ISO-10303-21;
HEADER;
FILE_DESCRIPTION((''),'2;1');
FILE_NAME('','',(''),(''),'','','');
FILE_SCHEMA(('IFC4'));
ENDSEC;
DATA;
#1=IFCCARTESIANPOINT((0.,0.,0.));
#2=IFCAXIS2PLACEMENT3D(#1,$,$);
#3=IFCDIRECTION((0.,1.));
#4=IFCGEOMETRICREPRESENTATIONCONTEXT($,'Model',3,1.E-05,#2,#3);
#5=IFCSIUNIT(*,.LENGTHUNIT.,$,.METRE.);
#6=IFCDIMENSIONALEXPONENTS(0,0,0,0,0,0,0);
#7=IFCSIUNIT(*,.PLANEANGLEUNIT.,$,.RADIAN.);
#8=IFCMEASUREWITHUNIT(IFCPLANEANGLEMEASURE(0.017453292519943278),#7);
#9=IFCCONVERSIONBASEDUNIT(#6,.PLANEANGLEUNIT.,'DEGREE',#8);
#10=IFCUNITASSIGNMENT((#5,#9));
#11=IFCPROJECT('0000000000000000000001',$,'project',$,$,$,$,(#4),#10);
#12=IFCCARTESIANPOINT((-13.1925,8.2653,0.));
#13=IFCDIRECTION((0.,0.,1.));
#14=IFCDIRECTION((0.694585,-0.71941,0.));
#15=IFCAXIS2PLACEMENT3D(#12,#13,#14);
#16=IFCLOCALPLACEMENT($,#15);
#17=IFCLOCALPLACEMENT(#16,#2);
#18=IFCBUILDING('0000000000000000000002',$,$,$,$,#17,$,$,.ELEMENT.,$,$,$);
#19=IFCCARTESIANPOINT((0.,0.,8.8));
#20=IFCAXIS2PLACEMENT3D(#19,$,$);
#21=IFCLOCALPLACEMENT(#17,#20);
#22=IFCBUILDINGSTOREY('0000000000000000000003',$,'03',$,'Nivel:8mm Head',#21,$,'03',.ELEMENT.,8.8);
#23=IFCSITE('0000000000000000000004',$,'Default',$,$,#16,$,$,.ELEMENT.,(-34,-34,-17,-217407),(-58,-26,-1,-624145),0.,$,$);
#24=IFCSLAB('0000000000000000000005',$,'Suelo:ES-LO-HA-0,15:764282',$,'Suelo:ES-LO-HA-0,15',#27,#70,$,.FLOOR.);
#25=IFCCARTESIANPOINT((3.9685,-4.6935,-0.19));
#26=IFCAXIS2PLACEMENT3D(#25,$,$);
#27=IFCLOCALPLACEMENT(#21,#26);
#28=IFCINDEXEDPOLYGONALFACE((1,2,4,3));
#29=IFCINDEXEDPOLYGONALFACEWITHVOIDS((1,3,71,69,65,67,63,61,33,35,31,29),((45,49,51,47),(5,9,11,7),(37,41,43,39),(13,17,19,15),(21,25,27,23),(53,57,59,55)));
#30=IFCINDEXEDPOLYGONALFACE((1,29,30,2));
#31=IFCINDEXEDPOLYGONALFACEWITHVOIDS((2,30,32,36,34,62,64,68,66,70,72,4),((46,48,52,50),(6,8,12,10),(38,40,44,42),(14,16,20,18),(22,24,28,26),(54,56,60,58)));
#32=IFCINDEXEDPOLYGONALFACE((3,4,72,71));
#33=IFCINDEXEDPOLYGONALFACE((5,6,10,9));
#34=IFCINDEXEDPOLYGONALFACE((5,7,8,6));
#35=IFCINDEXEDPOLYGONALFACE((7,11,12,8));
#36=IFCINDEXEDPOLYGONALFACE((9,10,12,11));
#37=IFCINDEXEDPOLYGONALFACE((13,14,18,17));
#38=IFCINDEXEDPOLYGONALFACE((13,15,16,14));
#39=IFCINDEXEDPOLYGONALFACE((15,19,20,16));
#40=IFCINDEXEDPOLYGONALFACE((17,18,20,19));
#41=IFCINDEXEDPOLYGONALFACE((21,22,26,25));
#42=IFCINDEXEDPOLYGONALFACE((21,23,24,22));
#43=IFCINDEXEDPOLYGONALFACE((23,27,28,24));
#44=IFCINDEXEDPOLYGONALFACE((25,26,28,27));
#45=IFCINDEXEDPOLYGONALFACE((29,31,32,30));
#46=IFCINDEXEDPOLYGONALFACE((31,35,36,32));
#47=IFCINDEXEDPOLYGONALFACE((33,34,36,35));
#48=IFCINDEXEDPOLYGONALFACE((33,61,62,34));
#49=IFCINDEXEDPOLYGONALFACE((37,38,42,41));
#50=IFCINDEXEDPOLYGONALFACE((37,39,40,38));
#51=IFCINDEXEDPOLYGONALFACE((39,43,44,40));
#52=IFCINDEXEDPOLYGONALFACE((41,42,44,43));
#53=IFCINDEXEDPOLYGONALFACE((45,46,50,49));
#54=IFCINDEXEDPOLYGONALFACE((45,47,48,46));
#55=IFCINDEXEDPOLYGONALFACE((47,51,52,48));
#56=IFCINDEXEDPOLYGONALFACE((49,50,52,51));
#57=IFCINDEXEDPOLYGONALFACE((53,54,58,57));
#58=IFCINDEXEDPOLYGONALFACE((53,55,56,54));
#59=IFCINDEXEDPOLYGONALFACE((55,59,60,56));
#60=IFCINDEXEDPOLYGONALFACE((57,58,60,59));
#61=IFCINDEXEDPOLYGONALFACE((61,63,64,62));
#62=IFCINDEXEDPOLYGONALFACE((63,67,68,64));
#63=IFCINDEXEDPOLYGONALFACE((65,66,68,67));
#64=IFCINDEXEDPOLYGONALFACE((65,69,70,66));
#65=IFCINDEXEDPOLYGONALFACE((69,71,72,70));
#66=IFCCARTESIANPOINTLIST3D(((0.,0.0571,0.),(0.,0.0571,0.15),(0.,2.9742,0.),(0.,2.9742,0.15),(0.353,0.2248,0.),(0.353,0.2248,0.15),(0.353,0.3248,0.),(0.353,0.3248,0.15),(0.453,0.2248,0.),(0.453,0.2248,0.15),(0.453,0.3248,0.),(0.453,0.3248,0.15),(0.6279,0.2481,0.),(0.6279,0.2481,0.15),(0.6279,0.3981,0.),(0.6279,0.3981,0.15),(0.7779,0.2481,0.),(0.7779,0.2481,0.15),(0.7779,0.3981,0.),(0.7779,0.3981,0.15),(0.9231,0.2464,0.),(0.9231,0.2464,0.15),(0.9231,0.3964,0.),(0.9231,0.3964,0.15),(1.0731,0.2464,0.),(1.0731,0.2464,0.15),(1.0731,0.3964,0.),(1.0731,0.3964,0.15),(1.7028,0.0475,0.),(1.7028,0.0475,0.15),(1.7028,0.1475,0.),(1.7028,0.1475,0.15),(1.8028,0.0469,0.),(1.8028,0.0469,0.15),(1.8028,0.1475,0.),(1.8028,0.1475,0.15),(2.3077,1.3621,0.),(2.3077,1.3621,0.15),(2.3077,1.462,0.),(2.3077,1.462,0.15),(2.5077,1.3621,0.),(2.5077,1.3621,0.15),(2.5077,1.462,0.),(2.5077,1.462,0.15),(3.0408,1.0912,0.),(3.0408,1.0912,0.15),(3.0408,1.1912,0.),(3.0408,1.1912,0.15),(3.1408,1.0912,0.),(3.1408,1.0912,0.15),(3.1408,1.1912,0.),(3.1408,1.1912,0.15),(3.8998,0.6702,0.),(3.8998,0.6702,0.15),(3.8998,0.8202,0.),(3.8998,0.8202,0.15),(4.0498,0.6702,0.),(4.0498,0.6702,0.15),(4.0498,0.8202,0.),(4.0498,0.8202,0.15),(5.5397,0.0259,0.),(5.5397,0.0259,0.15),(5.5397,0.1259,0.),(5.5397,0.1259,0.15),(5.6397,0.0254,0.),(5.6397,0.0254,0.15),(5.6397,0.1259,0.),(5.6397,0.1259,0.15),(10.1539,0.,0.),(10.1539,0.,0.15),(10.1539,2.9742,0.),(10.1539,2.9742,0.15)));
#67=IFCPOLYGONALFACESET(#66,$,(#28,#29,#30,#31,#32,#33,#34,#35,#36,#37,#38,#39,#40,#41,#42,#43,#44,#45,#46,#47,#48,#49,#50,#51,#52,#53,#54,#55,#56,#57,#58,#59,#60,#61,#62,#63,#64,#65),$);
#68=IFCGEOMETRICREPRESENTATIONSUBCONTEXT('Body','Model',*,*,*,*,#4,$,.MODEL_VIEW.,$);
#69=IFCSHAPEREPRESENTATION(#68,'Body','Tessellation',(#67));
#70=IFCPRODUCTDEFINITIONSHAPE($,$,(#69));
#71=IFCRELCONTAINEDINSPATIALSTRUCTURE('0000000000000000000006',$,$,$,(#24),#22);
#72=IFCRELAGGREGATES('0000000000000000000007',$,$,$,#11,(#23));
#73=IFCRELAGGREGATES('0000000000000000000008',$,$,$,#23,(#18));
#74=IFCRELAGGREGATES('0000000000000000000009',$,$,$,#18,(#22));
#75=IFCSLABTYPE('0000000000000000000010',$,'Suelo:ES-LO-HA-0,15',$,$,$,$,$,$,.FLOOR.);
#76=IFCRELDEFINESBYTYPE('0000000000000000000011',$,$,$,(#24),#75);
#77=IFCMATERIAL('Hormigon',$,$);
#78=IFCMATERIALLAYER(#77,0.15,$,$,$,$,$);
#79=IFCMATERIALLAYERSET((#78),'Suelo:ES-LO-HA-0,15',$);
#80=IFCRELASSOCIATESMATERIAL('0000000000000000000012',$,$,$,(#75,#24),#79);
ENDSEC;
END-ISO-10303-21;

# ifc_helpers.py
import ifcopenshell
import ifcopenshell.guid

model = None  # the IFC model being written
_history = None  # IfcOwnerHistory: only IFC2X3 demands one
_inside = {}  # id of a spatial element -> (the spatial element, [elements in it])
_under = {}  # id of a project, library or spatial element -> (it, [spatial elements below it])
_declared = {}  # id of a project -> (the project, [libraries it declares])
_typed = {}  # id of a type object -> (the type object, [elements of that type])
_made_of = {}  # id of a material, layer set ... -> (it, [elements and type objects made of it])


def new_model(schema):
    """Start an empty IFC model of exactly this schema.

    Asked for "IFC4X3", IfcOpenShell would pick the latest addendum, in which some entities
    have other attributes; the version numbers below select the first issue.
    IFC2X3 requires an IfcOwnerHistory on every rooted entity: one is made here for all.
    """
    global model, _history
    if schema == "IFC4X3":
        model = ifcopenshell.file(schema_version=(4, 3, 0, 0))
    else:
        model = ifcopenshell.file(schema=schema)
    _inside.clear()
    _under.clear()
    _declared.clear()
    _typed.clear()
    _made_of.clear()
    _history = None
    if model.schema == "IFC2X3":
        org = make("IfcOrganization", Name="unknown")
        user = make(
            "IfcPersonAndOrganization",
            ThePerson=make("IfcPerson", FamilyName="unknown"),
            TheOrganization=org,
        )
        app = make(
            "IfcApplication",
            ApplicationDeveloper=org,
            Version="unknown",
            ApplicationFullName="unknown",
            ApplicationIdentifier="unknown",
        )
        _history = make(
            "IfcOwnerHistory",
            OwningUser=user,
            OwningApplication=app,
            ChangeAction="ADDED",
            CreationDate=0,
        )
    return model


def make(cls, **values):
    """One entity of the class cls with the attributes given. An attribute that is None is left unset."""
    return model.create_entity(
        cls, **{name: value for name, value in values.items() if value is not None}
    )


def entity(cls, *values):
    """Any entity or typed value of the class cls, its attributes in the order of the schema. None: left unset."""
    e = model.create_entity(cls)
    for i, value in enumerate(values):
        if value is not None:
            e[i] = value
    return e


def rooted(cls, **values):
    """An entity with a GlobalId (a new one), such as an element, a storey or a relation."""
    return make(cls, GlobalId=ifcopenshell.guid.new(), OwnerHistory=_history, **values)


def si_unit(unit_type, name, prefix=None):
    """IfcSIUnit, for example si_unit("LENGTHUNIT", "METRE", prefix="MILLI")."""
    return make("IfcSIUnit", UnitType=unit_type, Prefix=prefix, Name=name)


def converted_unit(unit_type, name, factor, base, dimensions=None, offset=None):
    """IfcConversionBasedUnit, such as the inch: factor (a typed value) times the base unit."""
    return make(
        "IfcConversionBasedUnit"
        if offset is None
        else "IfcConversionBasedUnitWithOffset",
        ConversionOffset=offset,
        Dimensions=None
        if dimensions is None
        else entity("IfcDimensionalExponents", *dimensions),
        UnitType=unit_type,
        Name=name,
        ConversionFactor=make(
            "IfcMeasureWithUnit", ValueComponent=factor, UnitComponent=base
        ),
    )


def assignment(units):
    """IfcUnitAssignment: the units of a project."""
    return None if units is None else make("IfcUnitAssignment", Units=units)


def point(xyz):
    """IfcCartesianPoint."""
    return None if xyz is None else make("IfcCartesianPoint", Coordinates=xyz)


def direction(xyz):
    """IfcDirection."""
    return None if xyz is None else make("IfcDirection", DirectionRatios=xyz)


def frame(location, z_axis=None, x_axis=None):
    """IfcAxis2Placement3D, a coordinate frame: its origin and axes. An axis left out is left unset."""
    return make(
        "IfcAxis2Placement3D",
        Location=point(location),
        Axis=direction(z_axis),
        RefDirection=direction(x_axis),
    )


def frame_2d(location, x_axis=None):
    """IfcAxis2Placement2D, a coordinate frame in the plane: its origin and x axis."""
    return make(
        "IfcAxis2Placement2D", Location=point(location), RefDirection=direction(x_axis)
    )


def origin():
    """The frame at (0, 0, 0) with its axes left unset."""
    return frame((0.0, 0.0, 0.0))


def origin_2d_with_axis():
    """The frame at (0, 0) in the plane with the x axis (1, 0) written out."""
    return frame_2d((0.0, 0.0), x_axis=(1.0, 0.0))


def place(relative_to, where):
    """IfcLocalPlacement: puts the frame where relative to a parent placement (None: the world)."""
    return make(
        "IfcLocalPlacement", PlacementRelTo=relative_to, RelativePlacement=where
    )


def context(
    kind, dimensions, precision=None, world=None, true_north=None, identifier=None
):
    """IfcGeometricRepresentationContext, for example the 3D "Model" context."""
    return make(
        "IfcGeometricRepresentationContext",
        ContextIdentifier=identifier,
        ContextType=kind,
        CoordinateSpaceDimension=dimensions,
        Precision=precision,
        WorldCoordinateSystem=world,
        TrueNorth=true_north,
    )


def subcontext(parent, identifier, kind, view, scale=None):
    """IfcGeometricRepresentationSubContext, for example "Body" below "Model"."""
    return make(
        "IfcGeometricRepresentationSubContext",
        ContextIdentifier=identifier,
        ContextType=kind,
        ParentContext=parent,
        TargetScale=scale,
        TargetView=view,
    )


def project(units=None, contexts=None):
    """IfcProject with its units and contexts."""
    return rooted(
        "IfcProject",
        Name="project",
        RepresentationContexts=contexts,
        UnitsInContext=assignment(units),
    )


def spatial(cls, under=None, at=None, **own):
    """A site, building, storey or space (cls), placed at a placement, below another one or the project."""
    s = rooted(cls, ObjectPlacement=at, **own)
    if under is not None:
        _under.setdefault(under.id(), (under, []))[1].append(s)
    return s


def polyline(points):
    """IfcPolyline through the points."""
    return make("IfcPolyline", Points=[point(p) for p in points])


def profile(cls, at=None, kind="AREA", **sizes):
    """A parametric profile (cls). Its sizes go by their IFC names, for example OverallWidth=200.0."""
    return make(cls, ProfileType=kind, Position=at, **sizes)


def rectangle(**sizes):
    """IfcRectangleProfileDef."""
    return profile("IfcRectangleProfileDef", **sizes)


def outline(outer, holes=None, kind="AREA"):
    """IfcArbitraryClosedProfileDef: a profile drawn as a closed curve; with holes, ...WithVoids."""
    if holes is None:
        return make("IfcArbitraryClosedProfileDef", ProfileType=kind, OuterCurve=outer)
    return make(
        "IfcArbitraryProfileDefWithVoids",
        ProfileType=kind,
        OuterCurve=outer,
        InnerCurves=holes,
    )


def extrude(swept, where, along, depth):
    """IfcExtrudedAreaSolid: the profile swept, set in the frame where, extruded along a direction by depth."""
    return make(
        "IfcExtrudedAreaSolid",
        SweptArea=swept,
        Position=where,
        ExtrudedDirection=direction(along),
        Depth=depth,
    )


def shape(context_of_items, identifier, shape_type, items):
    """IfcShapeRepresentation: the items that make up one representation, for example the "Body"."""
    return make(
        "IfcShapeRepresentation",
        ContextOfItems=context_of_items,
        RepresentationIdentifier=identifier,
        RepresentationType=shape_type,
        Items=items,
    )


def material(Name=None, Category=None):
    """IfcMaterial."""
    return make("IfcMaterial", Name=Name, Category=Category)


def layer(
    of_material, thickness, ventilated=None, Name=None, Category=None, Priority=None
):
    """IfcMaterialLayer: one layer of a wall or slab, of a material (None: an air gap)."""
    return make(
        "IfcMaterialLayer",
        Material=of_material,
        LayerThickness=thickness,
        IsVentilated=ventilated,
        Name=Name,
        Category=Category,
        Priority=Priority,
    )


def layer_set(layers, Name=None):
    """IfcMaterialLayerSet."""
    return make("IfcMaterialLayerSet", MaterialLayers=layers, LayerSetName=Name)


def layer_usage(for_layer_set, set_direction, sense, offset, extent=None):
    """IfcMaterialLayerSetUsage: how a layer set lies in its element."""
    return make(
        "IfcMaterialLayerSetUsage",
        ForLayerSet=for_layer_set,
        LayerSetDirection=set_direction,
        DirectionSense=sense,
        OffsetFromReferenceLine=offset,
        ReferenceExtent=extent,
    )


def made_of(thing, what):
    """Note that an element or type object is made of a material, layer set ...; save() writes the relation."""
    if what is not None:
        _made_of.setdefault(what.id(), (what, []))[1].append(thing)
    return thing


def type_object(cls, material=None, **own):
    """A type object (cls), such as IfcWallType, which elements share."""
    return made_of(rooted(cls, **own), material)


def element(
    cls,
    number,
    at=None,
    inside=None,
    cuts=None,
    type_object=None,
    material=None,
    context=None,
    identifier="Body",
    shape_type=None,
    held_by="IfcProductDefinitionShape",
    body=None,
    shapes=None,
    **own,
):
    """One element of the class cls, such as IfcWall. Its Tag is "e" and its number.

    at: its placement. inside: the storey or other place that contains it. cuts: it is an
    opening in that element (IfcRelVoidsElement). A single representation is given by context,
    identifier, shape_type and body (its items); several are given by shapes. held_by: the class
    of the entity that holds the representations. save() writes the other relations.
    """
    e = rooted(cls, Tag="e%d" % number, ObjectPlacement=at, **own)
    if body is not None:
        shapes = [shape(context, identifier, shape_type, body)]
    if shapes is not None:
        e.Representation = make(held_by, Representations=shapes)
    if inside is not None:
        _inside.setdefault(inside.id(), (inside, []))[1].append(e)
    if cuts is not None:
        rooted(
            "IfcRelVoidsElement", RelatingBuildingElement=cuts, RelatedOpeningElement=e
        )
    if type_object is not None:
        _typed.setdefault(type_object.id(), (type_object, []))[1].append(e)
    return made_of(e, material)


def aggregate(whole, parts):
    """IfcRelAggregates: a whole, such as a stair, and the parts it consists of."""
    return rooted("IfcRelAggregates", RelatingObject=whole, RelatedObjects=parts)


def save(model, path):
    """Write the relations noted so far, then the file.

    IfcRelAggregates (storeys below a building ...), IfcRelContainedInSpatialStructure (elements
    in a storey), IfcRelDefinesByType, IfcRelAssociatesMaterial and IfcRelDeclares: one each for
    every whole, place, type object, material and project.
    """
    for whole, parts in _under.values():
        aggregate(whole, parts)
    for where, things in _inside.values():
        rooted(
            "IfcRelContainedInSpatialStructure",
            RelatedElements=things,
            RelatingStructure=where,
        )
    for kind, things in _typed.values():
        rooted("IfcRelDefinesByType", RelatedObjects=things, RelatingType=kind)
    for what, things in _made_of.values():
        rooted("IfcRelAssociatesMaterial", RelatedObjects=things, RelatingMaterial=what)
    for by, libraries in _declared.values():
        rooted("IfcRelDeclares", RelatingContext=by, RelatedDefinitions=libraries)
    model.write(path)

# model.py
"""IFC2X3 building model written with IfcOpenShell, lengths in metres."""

from ifc_helpers import new_model, entity, si_unit, converted_unit, direction, frame, frame_2d, origin, origin_2d_with_axis, place, context, subcontext, project, spatial, polyline, rectangle, outline, extrude, material, layer, layer_set, layer_usage, type_object, element, save


model = new_model("IFC2X3")

# Units and contexts
model_context = context("Model", 3, precision=1e-05, world=origin(), true_north=direction((0.0, 1.0)))
body_context = subcontext(model_context, "Body", "Model", "MODEL_VIEW")
ifc_project = project(units=[si_unit("LENGTHUNIT", "METRE"), converted_unit("PLANEANGLEUNIT", "DEGREE", entity("IfcPlaneAngleMeasure", 0.017453292519943278), si_unit("PLANEANGLEUNIT", "RADIAN"), dimensions=[0, 0, 0, 0, 0, 0, 0])], contexts=[model_context])

# Site, building, storey
site_placement = place(None, frame((-13.1925, 8.2653, 0.0), z_axis=(0.0, 0.0, 1.0), x_axis=(0.694585, -0.71941, 0.0)))
site = spatial("IfcSite", under=ifc_project, at=site_placement, Name="Default", CompositionType="ELEMENT", RefLatitude=(-34, -34, -17, -217407), RefLongitude=(-58, -26, -1, -624145), RefElevation=0.0)
building_placement = place(site_placement, origin())
building = spatial("IfcBuilding", under=site, at=building_placement, CompositionType="ELEMENT")
storey_placement = place(building_placement, frame((0.0, 0.0, 8.8)))
storey = spatial("IfcBuildingStorey", under=building, at=storey_placement, Name="03", ObjectType="Nivel:8mm Head", LongName="03", CompositionType="ELEMENT", Elevation=8.8)

# Shared definitions
ifc_material_1 = material(Name="Hormigon")

# Slab, openings
ifc_layer = layer(ifc_material_1, 0.15)
ifc_layer_set = layer_set([ifc_layer], Name="Suelo:ES-LO-HA-0,15")
ifc_layer_usage = layer_usage(ifc_layer_set, "AXIS3", "POSITIVE", 0.0)
slab_type = type_object("IfcSlabType", Name="Suelo:ES-LO-HA-0,15", PredefinedType="FLOOR", material=ifc_layer_set)
slab_placement = place(storey_placement, frame((3.9685, -4.6935, -0.19)))
slab = element("IfcSlab", 1, at=slab_placement, inside=storey, type_object=slab_type, material=ifc_layer_usage, Name="Suelo:ES-LO-HA-0,15:764282", ObjectType="Suelo:ES-LO-HA-0,15", PredefinedType="FLOOR", context=body_context, shape_type="SweptSolid", body=[
    extrude(outline(polyline([(-5.077, 1.4871), (-5.077, -1.4871), (-0.5627, -1.4617), (-0.5627, -1.3612), (-0.4627, -1.3612), (-0.4627, -1.4612), (3.2742, -1.4402), (3.2742, -1.3396), (3.3742, -1.3396), (3.3742, -1.4396), (5.077, -1.43), (5.077, 1.4871), (-5.077, 1.4871)])), frame((5.077, 1.4871, 0.15), z_axis=(0.0, 0.0, -1.0), x_axis=(-1.0, 0.0, 0.0)), (0.0, 0.0, 1.0), 0.15),
])
opening_1_placement = place(slab_placement, origin())
element("IfcOpeningElement", 2, at=opening_1_placement, cuts=slab, ObjectType="Opening", context=body_context, shape_type="SweptSolid", body=[
    extrude(rectangle(XDim=0.1, YDim=0.2, at=origin_2d_with_axis()), frame((2.4077, 1.412, 0.15), z_axis=(0.0, 0.0, -1.0), x_axis=(0.0, -1.0, 0.0)), (0.0, 0.0, 1.0), 0.15),
])
opening_2_placement = place(slab_placement, origin())
element("IfcOpeningElement", 3, at=opening_2_placement, cuts=slab, ObjectType="Opening", context=body_context, shape_type="SweptSolid", body=[
    extrude(rectangle(XDim=0.1, YDim=0.1, at=frame_2d((0.0, 0.0), x_axis=(1.0, 0.0))), frame((3.0908, 1.1412, 0.15), z_axis=(0.0, 0.0, -1.0), x_axis=(0.0, -1.0, 0.0)), (0.0, 0.0, 1.0), 0.15),
])
opening_3_placement = place(slab_placement, origin())
element("IfcOpeningElement", 4, at=opening_3_placement, cuts=slab, ObjectType="Opening", context=body_context, shape_type="SweptSolid", body=[
    extrude(rectangle(XDim=0.15, YDim=0.15, at=frame_2d((0.0, 0.0), x_axis=(1.0, 0.0))), frame((3.9748, 0.7452, 0.15), z_axis=(0.0, 0.0, -1.0), x_axis=(0.0, -1.0, 0.0)), (0.0, 0.0, 1.0), 0.15),
])
opening_4_placement = place(slab_placement, origin())
element("IfcOpeningElement", 5, at=opening_4_placement, cuts=slab, ObjectType="Opening", context=body_context, shape_type="SweptSolid", body=[
    extrude(rectangle(XDim=0.15, YDim=0.15, at=frame_2d((0.0, 0.0), x_axis=(1.0, 0.0))), frame((0.9981, 0.3214, 0.15), z_axis=(0.0, 0.0, -1.0), x_axis=(0.0, -1.0, 0.0)), (0.0, 0.0, 1.0), 0.15),
])
opening_5_placement = place(slab_placement, origin())
element("IfcOpeningElement", 6, at=opening_5_placement, cuts=slab, ObjectType="Opening", context=body_context, shape_type="SweptSolid", body=[
    extrude(rectangle(XDim=0.15, YDim=0.15, at=frame_2d((0.0, 0.0), x_axis=(1.0, 0.0))), frame((0.7029, 0.3231, 0.15), z_axis=(0.0, 0.0, 1.0), x_axis=(0.0, -1.0, 0.0)), (0.0, 0.0, -1.0), 0.15),
])
opening_6_placement = place(slab_placement, origin())
element("IfcOpeningElement", 7, at=opening_6_placement, cuts=slab, ObjectType="Opening", context=body_context, shape_type="SweptSolid", body=[
    extrude(rectangle(XDim=0.1, YDim=0.1, at=frame_2d((0.0, 0.0), x_axis=(1.0, 0.0))), frame((0.403, 0.2748, 0.15), z_axis=(0.0, 0.0, -1.0), x_axis=(0.0, -1.0, 0.0)), (0.0, 0.0, 1.0), 0.15),
])

save(model, "model.ifc")
